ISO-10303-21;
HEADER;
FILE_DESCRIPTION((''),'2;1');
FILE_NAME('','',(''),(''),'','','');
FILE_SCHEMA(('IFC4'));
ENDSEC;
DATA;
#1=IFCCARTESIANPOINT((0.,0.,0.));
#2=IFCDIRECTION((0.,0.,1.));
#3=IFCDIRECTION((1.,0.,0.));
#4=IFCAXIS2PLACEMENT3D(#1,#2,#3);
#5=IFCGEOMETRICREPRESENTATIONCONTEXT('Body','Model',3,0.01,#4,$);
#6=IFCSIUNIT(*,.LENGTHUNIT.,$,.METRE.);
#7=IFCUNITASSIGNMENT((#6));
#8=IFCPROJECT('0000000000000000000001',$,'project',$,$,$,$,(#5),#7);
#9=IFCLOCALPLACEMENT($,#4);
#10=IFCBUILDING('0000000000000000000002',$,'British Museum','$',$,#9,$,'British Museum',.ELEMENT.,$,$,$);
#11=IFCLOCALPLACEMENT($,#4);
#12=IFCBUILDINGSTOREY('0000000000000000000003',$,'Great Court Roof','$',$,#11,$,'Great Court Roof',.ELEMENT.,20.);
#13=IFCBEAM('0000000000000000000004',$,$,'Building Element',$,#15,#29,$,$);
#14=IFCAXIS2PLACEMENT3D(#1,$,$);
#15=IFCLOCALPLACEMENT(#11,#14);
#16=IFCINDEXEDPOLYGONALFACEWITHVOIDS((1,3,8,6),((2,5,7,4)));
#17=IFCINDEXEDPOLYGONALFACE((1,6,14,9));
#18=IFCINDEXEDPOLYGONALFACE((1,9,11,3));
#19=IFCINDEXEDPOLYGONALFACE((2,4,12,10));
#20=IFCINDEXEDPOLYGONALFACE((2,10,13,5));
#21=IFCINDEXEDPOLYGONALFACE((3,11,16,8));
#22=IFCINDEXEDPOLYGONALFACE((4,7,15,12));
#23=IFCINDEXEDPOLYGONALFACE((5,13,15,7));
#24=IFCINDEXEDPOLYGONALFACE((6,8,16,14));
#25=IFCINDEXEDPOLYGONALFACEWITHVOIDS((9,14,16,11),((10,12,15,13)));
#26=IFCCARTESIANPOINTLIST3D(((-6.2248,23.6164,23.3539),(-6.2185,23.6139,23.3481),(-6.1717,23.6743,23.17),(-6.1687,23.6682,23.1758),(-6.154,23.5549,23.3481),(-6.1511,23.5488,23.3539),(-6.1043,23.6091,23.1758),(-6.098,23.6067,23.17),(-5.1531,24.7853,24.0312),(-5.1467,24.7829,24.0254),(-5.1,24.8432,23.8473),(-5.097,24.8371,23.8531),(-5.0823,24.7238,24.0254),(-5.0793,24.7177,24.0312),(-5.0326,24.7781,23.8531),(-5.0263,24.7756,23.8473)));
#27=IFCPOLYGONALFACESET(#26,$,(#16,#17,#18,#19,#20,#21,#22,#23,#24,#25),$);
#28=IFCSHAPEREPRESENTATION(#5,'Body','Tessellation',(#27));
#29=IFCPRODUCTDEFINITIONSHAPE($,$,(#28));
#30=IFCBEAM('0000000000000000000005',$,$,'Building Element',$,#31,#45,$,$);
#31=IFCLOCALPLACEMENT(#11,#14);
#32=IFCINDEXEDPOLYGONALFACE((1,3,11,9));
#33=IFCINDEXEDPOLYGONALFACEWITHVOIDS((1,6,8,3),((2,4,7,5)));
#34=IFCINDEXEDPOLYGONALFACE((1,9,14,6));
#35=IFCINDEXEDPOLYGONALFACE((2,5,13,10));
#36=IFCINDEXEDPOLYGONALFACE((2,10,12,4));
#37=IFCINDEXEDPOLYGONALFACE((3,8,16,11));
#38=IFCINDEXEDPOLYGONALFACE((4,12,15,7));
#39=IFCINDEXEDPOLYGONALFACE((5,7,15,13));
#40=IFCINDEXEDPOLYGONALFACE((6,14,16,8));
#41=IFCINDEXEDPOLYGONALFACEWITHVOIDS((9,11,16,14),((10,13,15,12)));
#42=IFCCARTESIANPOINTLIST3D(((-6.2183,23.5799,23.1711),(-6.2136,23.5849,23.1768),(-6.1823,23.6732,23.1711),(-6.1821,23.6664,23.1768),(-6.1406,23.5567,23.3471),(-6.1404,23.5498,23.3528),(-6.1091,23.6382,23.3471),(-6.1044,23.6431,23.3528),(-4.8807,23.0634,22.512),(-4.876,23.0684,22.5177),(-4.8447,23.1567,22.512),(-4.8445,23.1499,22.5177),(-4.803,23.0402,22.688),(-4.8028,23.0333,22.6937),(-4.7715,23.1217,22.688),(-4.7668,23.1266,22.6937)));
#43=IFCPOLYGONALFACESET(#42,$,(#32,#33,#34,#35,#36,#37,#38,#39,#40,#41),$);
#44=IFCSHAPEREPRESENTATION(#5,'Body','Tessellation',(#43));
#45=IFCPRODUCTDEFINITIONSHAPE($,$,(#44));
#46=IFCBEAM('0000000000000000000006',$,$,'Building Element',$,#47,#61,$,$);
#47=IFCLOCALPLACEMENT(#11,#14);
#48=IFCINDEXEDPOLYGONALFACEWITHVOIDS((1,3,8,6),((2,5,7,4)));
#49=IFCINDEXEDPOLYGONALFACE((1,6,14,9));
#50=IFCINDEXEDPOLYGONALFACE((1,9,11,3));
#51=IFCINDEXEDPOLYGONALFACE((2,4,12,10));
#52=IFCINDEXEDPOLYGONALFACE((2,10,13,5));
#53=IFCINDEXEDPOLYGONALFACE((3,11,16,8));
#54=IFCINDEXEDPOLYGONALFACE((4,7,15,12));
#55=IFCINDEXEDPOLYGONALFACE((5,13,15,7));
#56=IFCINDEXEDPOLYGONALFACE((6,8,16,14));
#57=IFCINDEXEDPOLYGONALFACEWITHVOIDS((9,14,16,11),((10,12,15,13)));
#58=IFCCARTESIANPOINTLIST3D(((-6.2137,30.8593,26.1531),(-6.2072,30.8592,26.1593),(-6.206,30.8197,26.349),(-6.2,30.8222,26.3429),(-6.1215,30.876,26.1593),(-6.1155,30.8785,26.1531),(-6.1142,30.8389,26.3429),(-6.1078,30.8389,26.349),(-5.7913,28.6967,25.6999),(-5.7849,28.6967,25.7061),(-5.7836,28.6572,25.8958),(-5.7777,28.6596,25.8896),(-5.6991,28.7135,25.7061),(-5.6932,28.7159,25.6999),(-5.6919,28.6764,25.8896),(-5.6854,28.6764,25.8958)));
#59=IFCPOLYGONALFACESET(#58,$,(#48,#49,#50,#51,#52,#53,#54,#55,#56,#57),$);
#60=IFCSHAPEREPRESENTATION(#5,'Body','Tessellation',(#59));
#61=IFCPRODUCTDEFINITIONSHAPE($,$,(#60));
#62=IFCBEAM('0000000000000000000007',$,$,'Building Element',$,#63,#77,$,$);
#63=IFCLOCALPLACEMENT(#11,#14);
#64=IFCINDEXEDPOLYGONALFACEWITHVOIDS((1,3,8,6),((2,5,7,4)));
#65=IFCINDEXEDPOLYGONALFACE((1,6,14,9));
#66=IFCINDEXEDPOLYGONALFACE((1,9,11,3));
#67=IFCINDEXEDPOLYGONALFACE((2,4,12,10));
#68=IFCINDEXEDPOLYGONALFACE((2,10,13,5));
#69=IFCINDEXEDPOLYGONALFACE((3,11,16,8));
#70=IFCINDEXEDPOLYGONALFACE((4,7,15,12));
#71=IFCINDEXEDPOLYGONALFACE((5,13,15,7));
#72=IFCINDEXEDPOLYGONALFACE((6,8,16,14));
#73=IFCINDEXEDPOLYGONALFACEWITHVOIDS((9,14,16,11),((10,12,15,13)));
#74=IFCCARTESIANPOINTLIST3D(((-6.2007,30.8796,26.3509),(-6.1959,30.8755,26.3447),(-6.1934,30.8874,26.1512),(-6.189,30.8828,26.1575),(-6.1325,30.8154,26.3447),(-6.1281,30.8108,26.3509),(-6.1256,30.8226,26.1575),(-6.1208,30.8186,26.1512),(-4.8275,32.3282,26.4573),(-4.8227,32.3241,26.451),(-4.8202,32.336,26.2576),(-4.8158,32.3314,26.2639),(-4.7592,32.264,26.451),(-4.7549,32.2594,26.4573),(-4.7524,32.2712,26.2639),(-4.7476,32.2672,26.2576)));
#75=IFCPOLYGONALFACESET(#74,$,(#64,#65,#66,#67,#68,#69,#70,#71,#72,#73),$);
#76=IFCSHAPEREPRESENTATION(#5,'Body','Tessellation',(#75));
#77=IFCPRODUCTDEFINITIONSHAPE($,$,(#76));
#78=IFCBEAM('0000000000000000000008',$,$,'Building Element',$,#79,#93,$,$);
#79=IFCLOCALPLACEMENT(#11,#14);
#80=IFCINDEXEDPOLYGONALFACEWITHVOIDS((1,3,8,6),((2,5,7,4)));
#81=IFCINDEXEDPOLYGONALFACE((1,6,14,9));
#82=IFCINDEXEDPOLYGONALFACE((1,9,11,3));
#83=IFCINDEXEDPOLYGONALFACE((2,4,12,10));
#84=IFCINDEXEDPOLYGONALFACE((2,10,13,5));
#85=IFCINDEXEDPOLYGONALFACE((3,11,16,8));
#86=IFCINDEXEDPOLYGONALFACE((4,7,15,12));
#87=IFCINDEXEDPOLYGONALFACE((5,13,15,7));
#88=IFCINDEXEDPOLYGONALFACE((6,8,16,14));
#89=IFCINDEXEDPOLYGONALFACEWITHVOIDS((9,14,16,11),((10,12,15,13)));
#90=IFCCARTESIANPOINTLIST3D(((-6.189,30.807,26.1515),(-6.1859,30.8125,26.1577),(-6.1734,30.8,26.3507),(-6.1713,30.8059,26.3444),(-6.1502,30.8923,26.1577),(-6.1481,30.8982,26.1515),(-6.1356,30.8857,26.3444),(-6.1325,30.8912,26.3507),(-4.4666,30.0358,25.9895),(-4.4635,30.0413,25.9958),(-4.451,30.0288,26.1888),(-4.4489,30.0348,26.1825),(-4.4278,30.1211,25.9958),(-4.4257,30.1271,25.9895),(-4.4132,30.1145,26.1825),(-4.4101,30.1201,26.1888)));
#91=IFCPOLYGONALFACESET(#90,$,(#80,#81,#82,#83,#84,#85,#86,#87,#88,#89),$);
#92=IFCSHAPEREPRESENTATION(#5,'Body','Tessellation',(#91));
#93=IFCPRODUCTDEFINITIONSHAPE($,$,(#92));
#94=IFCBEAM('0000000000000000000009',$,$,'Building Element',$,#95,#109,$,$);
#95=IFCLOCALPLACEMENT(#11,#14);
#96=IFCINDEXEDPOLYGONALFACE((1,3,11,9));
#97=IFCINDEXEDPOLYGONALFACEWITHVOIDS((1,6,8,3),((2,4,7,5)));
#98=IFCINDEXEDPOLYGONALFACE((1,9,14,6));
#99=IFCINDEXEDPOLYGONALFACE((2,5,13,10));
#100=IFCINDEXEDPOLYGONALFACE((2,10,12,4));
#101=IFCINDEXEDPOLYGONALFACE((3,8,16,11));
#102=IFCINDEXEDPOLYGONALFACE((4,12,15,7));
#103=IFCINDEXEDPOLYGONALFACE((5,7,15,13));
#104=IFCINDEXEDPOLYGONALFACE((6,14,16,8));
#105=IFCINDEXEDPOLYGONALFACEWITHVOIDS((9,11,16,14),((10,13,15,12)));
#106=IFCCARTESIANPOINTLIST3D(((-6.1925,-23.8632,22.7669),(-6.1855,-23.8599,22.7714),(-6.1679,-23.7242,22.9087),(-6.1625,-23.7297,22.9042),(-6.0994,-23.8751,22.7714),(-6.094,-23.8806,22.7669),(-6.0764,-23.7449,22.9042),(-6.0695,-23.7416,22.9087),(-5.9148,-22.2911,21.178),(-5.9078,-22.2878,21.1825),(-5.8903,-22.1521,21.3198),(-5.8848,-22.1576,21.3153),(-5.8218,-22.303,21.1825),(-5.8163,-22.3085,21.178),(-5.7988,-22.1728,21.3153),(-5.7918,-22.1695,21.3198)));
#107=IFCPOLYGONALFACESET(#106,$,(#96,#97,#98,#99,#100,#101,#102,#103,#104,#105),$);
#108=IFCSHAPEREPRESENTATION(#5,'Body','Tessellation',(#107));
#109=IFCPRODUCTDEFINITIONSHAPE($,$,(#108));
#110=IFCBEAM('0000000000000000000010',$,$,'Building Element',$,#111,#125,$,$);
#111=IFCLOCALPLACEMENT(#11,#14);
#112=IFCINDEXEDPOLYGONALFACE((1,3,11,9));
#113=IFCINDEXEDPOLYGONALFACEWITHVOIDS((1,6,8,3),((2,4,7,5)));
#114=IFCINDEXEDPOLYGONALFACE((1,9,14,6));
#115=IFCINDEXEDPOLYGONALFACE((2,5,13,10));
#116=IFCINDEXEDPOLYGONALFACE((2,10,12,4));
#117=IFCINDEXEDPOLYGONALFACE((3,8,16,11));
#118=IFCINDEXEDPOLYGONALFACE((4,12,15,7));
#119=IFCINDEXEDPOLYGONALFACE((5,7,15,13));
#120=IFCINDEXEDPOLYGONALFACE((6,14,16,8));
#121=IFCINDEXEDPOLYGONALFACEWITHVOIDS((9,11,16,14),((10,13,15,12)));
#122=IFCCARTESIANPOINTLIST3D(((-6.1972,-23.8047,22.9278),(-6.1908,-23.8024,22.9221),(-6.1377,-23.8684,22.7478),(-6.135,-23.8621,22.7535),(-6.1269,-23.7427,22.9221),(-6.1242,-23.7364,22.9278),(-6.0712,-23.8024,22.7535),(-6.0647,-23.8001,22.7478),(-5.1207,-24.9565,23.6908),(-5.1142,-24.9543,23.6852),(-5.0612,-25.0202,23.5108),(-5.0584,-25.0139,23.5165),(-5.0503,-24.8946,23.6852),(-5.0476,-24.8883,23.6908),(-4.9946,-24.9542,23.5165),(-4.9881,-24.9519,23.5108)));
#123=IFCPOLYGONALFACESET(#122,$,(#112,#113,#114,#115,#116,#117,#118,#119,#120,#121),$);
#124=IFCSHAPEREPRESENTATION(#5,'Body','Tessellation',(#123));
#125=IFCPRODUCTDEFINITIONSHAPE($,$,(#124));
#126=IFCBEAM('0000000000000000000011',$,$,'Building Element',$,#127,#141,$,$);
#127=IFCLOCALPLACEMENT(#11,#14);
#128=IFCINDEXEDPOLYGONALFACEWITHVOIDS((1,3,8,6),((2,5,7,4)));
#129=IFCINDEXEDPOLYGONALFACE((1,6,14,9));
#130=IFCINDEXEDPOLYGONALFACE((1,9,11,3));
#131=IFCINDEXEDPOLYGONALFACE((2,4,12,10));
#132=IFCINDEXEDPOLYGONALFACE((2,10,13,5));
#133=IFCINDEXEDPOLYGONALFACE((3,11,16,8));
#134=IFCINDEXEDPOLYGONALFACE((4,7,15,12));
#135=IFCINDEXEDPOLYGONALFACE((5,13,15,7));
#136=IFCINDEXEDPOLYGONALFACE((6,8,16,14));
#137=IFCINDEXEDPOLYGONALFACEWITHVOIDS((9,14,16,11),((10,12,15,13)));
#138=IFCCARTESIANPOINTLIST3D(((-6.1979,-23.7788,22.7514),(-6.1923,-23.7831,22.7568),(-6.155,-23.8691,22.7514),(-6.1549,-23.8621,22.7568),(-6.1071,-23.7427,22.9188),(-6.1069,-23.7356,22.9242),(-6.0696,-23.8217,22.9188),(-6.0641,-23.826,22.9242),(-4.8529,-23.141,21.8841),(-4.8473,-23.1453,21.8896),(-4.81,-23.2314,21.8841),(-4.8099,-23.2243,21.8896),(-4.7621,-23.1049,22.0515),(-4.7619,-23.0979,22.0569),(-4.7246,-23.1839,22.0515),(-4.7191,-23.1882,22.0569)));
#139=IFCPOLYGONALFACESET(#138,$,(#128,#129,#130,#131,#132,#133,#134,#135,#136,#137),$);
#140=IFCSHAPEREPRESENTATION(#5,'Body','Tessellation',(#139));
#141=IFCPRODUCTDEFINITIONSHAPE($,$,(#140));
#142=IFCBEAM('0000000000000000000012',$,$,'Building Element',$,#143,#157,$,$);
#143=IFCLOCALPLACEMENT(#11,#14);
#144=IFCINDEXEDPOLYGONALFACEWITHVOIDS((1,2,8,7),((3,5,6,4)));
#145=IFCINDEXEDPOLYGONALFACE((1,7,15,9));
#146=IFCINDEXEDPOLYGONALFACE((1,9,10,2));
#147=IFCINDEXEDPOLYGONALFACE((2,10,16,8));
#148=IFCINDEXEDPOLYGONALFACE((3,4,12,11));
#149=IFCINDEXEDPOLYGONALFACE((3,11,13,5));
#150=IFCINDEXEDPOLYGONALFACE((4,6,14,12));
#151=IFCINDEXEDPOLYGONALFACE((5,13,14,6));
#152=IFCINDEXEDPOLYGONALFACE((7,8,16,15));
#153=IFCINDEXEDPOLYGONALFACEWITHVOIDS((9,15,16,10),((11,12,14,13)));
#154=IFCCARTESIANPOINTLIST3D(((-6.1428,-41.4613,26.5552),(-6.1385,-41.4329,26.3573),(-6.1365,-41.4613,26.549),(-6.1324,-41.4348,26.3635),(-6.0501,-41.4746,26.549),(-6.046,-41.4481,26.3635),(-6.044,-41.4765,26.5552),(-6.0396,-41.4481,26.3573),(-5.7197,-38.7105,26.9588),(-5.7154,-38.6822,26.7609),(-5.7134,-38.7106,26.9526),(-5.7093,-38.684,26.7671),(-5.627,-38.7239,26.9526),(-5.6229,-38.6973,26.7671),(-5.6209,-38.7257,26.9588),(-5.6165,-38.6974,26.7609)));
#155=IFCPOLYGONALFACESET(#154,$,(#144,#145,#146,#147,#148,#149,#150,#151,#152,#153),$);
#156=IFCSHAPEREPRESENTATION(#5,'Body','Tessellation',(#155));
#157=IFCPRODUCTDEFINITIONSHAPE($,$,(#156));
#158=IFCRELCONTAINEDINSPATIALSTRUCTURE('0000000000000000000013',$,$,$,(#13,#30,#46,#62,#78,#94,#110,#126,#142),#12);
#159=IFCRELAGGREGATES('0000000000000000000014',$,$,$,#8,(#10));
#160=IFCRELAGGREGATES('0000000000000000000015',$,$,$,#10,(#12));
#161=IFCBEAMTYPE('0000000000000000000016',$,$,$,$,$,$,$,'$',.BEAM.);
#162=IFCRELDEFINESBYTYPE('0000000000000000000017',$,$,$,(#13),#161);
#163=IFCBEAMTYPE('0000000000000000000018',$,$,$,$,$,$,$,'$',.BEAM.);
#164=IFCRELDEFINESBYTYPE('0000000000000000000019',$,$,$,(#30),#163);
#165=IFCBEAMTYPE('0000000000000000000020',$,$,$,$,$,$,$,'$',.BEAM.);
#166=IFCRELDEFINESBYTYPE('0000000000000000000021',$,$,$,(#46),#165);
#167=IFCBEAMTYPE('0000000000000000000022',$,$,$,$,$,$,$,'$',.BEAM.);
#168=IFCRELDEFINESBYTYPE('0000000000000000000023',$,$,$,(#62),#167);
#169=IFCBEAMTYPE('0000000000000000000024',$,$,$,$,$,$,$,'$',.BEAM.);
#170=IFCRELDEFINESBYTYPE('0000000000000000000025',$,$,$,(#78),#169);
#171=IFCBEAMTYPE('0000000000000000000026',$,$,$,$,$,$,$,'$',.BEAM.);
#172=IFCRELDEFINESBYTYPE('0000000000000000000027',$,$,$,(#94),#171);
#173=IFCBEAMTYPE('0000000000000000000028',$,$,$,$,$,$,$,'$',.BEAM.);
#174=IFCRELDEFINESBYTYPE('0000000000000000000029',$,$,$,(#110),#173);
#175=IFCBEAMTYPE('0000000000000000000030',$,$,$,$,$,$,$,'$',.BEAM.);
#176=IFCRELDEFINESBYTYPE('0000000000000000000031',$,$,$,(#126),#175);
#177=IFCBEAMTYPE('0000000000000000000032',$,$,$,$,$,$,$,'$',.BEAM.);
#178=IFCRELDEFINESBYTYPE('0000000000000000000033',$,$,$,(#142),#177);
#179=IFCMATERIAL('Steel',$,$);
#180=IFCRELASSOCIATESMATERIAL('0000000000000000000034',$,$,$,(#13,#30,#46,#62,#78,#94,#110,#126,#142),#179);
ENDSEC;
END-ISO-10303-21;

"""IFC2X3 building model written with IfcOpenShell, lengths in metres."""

from ifc_helpers import new_model, si_unit, frame, origin_with_axes, origin_2d, place, context, project, spatial, hollow_rectangle, extrude, material, type_object, element, save


model = new_model("IFC2X3")

# Units and contexts
model_context = context("Model", 3, precision=0.01, world=origin_with_axes(), identifier="Body")
ifc_project = project(units=[si_unit("LENGTHUNIT", "METRE")], contexts=[model_context])

# Building, storey
building_placement = place(None, origin_with_axes())
building = spatial("IfcBuilding", under=ifc_project, at=building_placement, Name="British Museum", Description="$", LongName="British Museum", CompositionType="ELEMENT")
storey_placement = place(None, origin_with_axes())
storey = spatial("IfcBuildingStorey", under=building, at=storey_placement, Name="Great Court Roof", Description="$", LongName="Great Court Roof", CompositionType="ELEMENT", Elevation=20.0)

# Beams
ifc_material = material(Name="Steel")
beam_type_1 = type_object("IfcBeamType", ElementType="$", PredefinedType="BEAM")
beam_1_placement = place(None, origin_with_axes())
element("IfcBeam", 1, at=beam_1_placement, inside=storey, type_object=beam_type_1, material=ifc_material, Description="Building Element", context=model_context, shape_type="SweptSolid", body=[
    extrude(hollow_rectangle(XDim=0.1, YDim=0.2, WallThickness=0.0063, InnerFilletRadius=-0.0063, OuterFilletRadius=0.0, at=origin_2d()), frame((-6.1614, 23.6115, 23.262), z_axis=(0.621485, 0.677856, 0.39277), x_axis=(-0.737091, 0.675794, 0.0)), (0.0, 0.0, 1.0), 1.7245),
])
beam_type_2 = type_object("IfcBeamType", ElementType="$", PredefinedType="BEAM")
beam_2_placement = place(None, origin_with_axes())
element("IfcBeam", 2, at=beam_2_placement, inside=storey, type_object=beam_type_2, material=ifc_material, Description="Building Element", context=model_context, shape_type="SweptSolid", body=[
    extrude(hollow_rectangle(XDim=0.1, YDim=0.2, WallThickness=0.0063, InnerFilletRadius=-0.0063, OuterFilletRadius=0.0, at=origin_2d()), frame((-6.1614, 23.6115, 23.262), z_axis=(0.847614, -0.327297, -0.417646), x_axis=(0.360218, 0.932868, 0.0)), (0.0, 0.0, 1.0), 1.5781),
])
beam_type_3 = type_object("IfcBeamType", ElementType="$", PredefinedType="BEAM")
beam_3_placement = place(None, origin_with_axes())
element("IfcBeam", 3, at=beam_3_placement, inside=storey, type_object=beam_type_3, material=ifc_material, Description="Building Element", context=model_context, shape_type="SweptSolid", body=[
    extrude(hollow_rectangle(XDim=0.1, YDim=0.2, WallThickness=0.0063, InnerFilletRadius=-0.0063, OuterFilletRadius=0.0, at=origin_2d()), frame((-6.1607, 30.8491, 26.2511), z_axis=(0.187753, -0.961328, -0.201487), x_axis=(0.981457, 0.191685, 0.0)), (0.0, 0.0, 1.0), 2.2495),
])
beam_type_4 = type_object("IfcBeamType", ElementType="$", PredefinedType="BEAM")
beam_4_placement = place(None, origin_with_axes())
element("IfcBeam", 4, at=beam_4_placement, inside=storey, type_object=beam_type_4, material=ifc_material, Description="Building Element", context=model_context, shape_type="SweptSolid", body=[
    extrude(hollow_rectangle(XDim=0.1, YDim=0.2, WallThickness=0.0063, InnerFilletRadius=-0.0063, OuterFilletRadius=0.0, at=origin_2d()), frame((-6.1607, 30.8491, 26.2511), z_axis=(0.686996, 0.72471, 0.053209), x_axis=(-0.725738, 0.687971, 0.0)), (0.0, 0.0, 1.0), 1.9989),
])
beam_type_5 = type_object("IfcBeamType", ElementType="$", PredefinedType="BEAM")
beam_5_placement = place(None, origin_with_axes())
element("IfcBeam", 5, at=beam_5_placement, inside=storey, type_object=beam_type_5, material=ifc_material, Description="Building Element", context=model_context, shape_type="SweptSolid", body=[
    extrude(hollow_rectangle(XDim=0.1, YDim=0.2, WallThickness=0.0063, InnerFilletRadius=-0.0063, OuterFilletRadius=0.0, at=origin_2d()), frame((-6.1607, 30.8491, 26.2511), z_axis=(0.909356, -0.407139, -0.085496), x_axis=(0.408635, 0.912698, 0.0)), (0.0, 0.0, 1.0), 1.8941),
])
beam_type_6 = type_object("IfcBeamType", ElementType="$", PredefinedType="BEAM")
beam_6_placement = place(None, origin_with_axes())
element("IfcBeam", 6, at=beam_6_placement, inside=storey, type_object=beam_type_6, material=ifc_material, Description="Building Element", context=model_context, shape_type="SweptSolid", body=[
    extrude(hollow_rectangle(XDim=0.1, YDim=0.2, WallThickness=0.0063, InnerFilletRadius=-0.0063, OuterFilletRadius=0.0, at=origin_2d()), frame((-6.131, -23.8024, 22.8378), z_axis=(0.123279, 0.697966, -0.70544), x_axis=(-0.984757, 0.173934, 0.0)), (0.0, 0.0, 1.0), 2.2524),
])
beam_type_7 = type_object("IfcBeamType", ElementType="$", PredefinedType="BEAM")
beam_7_placement = place(None, origin_with_axes())
element("IfcBeam", 7, at=beam_7_placement, inside=storey, type_object=beam_type_7, material=ifc_material, Description="Building Element", context=model_context, shape_type="SweptSolid", body=[
    extrude(hollow_rectangle(XDim=0.1, YDim=0.2, WallThickness=0.0063, InnerFilletRadius=-0.0063, OuterFilletRadius=0.0, at=origin_2d()), frame((-6.131, -23.8024, 22.8378), z_axis=(0.614638, -0.65761, 0.435625), x_axis=(0.730574, 0.682834, 0.0)), (0.0, 0.0, 1.0), 1.7516),
])
beam_type_8 = type_object("IfcBeamType", ElementType="$", PredefinedType="BEAM")
beam_8_placement = place(None, origin_with_axes())
element("IfcBeam", 8, at=beam_8_placement, inside=storey, type_object=beam_type_8, material=ifc_material, Description="Building Element", context=model_context, shape_type="SweptSolid", body=[
    extrude(hollow_rectangle(XDim=0.1, YDim=0.2, WallThickness=0.0063, InnerFilletRadius=-0.0063, OuterFilletRadius=0.0, at=origin_2d()), frame((-6.131, -23.8024, 22.8378), z_axis=(0.780713, 0.370201, -0.503426), x_axis=(-0.428455, 0.903563, 0.0)), (0.0, 0.0, 1.0), 1.7228),
])
beam_type_9 = type_object("IfcBeamType", ElementType="$", PredefinedType="BEAM")
beam_9_placement = place(None, origin_with_axes())
element("IfcBeam", 9, at=beam_9_placement, inside=storey, type_object=beam_type_9, material=ifc_material, Description="Building Element", context=model_context, shape_type="SweptSolid", body=[
    extrude(hollow_rectangle(XDim=0.1, YDim=0.2, WallThickness=0.0063, InnerFilletRadius=-0.0063, OuterFilletRadius=0.0, at=origin_2d()), frame((-6.0912, -41.4547, 26.4563), z_axis=(0.150454, 0.978147, 0.143496), x_axis=(-0.988376, 0.152028, 0.0)), (0.0, 0.0, 1.0), 2.8122),
])

save(model, "model.ifc")
